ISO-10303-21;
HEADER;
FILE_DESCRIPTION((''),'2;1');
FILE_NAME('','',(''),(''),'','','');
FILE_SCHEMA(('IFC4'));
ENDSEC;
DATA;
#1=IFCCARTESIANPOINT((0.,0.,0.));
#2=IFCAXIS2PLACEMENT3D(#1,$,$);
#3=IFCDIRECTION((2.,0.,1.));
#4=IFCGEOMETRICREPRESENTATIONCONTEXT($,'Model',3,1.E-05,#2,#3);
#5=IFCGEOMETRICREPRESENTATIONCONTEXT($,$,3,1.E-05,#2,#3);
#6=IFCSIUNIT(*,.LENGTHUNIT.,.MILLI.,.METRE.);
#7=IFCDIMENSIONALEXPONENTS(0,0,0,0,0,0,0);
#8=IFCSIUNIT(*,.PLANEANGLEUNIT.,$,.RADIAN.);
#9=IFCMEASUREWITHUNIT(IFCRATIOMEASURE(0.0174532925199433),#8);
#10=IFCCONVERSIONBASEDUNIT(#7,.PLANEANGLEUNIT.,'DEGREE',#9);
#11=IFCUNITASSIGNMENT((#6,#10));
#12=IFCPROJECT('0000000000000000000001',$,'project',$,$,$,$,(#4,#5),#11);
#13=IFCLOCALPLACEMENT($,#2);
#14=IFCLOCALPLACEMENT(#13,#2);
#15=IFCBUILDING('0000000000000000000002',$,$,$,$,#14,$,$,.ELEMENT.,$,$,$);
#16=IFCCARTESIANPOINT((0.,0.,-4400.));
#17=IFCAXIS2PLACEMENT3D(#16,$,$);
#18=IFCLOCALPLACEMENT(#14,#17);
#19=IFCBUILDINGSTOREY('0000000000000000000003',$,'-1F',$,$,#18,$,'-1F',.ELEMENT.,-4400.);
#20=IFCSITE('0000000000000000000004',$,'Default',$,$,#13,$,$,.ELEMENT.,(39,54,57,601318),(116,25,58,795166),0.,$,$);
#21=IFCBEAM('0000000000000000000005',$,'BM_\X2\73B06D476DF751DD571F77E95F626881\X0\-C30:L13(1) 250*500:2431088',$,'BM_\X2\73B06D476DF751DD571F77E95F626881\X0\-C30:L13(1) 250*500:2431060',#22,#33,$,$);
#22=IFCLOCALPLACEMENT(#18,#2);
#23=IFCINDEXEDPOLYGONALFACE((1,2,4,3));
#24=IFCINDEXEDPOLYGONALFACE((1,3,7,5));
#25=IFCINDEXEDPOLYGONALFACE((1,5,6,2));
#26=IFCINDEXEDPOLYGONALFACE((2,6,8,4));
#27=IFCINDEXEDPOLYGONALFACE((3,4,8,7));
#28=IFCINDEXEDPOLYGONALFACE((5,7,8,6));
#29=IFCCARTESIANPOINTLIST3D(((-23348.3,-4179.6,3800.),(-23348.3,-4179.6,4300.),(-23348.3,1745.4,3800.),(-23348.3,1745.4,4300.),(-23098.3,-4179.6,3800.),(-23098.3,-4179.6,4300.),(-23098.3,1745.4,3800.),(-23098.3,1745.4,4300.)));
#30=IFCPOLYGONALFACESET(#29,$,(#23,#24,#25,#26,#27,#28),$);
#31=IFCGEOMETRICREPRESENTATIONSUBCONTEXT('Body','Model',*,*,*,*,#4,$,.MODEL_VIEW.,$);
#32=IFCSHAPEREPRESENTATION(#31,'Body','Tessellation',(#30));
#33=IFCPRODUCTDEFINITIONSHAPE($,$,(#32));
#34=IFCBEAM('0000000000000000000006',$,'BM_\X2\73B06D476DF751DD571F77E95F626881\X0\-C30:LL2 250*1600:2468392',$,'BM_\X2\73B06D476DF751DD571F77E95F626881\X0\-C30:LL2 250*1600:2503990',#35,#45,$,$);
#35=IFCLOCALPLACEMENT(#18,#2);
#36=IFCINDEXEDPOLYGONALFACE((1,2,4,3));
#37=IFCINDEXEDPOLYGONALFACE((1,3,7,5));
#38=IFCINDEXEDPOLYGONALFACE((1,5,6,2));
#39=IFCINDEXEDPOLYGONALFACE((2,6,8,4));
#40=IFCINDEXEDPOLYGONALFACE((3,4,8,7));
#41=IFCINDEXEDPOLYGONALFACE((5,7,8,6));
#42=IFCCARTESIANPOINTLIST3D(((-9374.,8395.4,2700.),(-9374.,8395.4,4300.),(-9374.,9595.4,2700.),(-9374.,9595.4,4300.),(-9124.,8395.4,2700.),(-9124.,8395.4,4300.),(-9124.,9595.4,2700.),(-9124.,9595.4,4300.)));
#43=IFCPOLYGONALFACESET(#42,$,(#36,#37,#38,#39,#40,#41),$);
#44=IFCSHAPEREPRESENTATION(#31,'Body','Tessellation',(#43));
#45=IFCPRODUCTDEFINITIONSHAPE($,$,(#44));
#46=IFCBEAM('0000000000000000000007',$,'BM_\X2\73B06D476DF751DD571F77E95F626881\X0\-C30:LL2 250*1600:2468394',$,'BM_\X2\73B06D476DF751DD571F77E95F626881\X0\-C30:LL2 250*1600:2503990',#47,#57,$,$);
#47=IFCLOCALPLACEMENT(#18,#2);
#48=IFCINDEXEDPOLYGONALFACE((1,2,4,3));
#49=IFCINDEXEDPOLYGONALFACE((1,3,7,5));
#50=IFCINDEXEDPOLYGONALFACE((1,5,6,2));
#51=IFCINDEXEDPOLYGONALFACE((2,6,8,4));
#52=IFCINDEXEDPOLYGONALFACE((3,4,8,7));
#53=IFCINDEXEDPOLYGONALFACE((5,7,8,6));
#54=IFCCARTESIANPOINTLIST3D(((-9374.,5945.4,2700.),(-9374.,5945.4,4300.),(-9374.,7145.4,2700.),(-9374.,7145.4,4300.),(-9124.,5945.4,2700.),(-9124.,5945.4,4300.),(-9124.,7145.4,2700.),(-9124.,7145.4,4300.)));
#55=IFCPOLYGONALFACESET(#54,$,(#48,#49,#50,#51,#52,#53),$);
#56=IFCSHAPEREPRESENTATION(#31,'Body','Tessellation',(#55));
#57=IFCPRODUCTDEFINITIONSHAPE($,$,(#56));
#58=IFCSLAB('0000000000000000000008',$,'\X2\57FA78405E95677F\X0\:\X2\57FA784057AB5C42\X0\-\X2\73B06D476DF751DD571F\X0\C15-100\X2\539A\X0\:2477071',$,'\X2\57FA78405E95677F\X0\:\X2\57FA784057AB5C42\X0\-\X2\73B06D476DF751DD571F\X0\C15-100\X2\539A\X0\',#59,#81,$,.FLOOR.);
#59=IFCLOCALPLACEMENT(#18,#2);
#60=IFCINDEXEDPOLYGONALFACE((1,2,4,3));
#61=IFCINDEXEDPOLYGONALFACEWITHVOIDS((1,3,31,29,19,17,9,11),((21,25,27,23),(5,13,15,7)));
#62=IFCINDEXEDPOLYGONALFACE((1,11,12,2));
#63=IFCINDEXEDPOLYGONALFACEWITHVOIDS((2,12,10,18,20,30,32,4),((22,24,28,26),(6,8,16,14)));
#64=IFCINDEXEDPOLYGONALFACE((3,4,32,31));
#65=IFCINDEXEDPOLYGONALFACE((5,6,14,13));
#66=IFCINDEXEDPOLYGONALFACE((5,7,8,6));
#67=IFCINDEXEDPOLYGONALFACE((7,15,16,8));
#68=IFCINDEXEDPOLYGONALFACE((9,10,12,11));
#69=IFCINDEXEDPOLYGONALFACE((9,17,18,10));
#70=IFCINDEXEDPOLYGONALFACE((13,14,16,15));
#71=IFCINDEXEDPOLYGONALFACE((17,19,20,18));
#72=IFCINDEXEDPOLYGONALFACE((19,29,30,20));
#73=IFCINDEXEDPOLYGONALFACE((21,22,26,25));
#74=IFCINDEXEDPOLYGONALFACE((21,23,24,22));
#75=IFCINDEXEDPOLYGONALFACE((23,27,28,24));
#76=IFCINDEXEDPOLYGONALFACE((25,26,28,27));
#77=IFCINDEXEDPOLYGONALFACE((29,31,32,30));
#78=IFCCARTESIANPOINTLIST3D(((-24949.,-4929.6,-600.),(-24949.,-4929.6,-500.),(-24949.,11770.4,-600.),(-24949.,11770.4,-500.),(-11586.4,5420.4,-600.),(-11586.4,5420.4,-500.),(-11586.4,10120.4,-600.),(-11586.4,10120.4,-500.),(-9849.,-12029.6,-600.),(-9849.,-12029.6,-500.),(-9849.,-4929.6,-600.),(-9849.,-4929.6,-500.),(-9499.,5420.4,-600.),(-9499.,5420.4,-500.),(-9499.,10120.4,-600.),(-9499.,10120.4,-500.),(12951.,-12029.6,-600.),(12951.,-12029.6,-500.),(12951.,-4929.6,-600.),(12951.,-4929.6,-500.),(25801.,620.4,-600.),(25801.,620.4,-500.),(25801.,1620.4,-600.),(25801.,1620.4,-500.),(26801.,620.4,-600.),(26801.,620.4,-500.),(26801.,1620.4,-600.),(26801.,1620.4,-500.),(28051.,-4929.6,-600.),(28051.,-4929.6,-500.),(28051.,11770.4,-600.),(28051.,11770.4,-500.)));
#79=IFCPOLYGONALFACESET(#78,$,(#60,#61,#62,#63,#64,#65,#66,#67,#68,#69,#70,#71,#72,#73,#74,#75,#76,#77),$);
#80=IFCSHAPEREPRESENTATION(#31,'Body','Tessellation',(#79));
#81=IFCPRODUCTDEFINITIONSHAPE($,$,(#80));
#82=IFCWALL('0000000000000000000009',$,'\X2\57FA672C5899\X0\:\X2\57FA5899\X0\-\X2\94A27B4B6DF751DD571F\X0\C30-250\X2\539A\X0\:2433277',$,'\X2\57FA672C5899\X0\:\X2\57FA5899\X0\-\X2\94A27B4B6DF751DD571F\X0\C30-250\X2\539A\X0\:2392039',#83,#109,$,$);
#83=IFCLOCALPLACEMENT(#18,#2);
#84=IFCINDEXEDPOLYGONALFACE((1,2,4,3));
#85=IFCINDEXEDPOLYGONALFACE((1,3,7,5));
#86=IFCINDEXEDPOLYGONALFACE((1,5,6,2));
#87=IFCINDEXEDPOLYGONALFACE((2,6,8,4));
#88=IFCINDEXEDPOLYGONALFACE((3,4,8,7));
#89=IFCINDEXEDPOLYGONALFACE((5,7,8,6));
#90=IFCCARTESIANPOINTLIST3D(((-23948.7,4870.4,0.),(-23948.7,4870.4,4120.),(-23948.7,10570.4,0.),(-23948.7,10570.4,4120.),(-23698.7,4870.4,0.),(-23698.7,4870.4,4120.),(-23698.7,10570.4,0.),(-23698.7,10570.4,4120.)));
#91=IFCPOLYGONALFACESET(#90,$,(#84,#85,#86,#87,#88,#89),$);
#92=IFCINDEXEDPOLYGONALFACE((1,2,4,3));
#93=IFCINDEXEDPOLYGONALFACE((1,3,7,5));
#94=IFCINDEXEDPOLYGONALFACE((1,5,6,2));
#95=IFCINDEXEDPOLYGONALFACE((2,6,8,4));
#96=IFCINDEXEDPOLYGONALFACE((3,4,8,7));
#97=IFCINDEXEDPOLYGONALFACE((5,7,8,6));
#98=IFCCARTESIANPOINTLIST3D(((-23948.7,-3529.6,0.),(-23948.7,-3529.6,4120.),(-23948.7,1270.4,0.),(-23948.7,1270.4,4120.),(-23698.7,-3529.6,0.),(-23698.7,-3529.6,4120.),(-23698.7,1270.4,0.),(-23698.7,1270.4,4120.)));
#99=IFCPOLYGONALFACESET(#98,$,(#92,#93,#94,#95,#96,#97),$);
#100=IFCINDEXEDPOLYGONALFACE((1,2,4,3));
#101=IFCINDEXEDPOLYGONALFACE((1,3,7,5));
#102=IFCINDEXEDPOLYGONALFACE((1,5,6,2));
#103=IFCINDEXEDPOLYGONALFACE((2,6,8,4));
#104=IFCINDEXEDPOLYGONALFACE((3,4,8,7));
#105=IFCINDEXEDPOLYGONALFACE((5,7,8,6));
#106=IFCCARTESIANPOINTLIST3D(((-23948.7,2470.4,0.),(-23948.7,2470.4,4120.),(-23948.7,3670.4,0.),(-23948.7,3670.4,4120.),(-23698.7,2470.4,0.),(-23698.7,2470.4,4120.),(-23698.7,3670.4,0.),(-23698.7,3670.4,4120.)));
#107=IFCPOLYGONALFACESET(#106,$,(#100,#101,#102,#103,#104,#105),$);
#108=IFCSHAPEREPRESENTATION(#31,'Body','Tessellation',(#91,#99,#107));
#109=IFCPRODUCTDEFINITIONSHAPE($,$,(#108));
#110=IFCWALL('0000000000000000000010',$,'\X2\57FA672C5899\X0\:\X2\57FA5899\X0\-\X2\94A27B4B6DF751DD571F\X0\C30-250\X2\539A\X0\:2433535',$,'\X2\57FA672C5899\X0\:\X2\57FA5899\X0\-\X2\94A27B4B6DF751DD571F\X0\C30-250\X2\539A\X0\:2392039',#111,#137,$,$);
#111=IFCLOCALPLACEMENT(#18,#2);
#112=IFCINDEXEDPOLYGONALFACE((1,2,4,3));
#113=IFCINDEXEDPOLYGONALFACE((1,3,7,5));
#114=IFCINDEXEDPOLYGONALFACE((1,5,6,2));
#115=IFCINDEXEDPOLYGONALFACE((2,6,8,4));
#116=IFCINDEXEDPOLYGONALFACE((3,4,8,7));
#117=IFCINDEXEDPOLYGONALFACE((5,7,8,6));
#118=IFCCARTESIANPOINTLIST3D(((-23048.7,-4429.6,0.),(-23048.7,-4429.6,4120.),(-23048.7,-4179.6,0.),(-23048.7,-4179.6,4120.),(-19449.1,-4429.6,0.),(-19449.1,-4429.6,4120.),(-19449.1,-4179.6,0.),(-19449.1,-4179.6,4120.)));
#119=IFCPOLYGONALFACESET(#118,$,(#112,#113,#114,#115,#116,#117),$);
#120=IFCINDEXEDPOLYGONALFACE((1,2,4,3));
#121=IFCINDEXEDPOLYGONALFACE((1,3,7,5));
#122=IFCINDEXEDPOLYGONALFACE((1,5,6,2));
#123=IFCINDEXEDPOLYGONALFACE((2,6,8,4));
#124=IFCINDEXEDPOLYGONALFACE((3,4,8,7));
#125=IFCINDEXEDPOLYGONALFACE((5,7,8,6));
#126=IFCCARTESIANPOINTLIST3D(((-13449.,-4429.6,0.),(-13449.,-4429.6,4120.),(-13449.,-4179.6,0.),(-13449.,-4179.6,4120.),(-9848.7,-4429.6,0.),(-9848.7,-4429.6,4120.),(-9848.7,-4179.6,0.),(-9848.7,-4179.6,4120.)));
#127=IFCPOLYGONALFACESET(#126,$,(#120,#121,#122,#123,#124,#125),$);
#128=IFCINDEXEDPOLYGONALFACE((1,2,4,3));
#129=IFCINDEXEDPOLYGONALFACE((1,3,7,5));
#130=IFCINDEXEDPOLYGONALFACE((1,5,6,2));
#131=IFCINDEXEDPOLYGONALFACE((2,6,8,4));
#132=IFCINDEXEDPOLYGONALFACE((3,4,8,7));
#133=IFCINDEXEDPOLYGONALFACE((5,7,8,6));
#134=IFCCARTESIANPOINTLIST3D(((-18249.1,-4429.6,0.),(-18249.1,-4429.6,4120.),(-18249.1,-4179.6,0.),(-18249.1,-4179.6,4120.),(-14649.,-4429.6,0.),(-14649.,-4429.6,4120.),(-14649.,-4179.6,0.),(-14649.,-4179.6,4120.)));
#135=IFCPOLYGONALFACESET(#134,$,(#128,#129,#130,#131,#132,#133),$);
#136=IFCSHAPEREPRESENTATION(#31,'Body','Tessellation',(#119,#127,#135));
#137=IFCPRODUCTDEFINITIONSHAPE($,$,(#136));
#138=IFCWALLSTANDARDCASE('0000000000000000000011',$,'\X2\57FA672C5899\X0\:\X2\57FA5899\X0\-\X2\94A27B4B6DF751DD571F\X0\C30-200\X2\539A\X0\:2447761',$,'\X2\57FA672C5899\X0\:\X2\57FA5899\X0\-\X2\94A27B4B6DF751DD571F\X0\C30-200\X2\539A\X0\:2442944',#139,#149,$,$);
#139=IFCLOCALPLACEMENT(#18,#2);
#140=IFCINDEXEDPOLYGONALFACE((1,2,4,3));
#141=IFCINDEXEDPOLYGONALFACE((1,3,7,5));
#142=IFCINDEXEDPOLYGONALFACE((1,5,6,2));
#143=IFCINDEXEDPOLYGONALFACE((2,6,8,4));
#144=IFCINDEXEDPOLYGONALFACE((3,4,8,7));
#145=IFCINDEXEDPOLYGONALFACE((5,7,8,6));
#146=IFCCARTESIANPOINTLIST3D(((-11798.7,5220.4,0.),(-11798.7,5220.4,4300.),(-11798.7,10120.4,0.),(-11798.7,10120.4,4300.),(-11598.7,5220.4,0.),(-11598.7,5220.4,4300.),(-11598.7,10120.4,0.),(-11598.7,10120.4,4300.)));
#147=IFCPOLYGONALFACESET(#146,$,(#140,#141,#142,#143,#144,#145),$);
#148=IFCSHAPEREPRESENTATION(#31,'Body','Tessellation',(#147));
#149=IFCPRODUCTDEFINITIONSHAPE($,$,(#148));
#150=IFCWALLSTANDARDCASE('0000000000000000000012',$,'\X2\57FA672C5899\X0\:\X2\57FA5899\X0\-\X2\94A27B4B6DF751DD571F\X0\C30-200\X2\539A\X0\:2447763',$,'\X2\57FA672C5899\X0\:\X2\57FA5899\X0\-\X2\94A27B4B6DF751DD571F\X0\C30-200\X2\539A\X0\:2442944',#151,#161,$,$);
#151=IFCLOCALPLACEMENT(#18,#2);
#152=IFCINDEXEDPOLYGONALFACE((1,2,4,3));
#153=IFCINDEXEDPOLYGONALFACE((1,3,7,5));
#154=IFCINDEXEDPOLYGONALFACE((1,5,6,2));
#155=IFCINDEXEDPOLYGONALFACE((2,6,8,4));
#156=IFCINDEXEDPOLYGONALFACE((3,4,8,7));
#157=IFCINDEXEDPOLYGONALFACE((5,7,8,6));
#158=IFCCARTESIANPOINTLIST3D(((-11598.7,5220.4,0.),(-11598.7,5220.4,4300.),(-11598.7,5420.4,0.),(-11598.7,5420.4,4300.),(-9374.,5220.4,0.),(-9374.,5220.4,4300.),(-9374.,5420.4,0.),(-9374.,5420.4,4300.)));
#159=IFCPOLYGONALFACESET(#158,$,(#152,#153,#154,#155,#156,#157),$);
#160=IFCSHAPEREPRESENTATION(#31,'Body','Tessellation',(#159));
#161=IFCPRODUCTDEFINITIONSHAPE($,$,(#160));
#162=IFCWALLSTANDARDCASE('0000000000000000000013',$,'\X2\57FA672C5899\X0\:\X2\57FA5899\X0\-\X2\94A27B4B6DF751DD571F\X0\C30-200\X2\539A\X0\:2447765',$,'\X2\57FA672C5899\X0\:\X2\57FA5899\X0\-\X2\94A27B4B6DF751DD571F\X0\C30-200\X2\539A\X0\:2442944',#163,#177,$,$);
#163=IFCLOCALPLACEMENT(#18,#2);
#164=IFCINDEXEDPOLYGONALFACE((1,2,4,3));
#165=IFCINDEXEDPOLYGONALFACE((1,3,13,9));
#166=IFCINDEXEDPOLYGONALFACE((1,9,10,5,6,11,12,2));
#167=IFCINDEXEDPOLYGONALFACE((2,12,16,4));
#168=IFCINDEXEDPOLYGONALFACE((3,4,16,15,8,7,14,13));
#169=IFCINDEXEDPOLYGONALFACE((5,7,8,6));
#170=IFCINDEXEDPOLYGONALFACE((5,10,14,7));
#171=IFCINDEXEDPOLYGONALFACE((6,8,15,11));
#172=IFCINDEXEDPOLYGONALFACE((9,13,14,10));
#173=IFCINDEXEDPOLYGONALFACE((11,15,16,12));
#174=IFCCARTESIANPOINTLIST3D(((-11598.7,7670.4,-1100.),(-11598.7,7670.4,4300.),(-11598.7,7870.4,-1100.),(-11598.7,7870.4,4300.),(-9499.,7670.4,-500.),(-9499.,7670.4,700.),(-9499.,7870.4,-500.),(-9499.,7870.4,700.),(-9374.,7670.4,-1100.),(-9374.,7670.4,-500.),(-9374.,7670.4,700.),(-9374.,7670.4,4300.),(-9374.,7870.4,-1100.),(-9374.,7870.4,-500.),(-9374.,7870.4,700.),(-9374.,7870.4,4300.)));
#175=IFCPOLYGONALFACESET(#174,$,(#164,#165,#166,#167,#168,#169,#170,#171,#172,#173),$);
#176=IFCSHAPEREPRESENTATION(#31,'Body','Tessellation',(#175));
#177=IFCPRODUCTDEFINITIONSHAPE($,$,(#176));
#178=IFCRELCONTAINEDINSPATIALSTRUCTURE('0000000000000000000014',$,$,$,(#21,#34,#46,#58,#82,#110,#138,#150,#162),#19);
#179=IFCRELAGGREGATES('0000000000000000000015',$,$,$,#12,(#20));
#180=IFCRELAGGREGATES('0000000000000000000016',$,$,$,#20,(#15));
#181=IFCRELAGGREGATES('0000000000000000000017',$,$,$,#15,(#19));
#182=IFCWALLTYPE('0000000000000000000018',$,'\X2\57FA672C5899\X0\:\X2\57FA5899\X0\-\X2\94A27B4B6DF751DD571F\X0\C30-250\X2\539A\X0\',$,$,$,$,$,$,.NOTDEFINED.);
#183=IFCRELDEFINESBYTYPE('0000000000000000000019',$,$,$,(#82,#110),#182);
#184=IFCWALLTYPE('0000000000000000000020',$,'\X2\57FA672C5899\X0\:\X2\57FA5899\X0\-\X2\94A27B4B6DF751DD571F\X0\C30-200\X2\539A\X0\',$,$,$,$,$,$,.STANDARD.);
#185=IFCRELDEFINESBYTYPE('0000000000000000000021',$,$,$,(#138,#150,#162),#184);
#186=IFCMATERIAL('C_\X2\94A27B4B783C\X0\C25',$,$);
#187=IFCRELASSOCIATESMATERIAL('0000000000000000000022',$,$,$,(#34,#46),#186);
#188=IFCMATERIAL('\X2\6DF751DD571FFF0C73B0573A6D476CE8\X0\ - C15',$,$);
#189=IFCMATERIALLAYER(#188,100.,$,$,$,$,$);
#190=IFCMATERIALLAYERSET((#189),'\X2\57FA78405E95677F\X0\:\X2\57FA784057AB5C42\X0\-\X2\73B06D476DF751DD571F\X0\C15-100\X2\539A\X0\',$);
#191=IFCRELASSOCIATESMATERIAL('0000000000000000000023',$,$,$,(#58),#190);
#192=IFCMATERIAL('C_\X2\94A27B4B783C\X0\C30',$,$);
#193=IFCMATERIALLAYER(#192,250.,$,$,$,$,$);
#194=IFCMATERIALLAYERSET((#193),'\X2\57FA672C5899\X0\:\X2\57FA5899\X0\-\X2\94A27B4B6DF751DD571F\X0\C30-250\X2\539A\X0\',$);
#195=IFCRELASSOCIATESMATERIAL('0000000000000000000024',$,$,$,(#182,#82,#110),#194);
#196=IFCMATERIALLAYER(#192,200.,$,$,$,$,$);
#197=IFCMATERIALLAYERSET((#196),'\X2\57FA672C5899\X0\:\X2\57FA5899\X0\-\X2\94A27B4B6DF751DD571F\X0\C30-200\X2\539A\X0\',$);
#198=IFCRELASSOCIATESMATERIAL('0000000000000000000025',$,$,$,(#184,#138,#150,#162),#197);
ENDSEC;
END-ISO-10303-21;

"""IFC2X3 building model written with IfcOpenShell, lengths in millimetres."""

from ifc_helpers import new_model, entity, si_unit, converted_unit, direction, frame, frame_2d, origin, origin_2d_with_axis, place, context, subcontext, project, spatial, polyline, rectangle, outline, extrude, clip, bounded_halfspace, material, layer, layer_set, layer_usage, type_object, element, save


model = new_model("IFC2X3")

# Units and contexts
model_context = context("Model", 3, precision=1e-05, world=origin(), true_north=direction((2.0, 0.0, 1.0)))
context_of_model = context(None, 3, precision=1e-05, world=origin(), true_north=direction((2.0, 0.0, 1.0)))
body_context = subcontext(model_context, "Body", "Model", "MODEL_VIEW")
ifc_project = project(units=[si_unit("LENGTHUNIT", "METRE", prefix="MILLI"), converted_unit("PLANEANGLEUNIT", "DEGREE", entity("IfcRatioMeasure", 0.0174532925199433), si_unit("PLANEANGLEUNIT", "RADIAN"), dimensions=[0, 0, 0, 0, 0, 0, 0])], contexts=[model_context, context_of_model])

# Site, building, storey
site_placement = place(None, origin())
site = spatial("IfcSite", under=ifc_project, at=site_placement, Name="Default", CompositionType="ELEMENT", RefLatitude=(39, 54, 57, 601318), RefLongitude=(116, 25, 58, 795166), RefElevation=0.0)
building_placement = place(site_placement, origin())
building = spatial("IfcBuilding", under=site, at=building_placement, CompositionType="ELEMENT")
storey_placement = place(building_placement, frame((0.0, 0.0, -4400.0)))
storey = spatial("IfcBuildingStorey", under=building, at=storey_placement, Name="-1F", LongName="-1F", CompositionType="ELEMENT", Elevation=-4400.0)

# Beams
ifc_material_1 = material(Name="C_钢筋砼C30")
beam_1_placement = place(storey_placement, frame((-23223.3, -4179.6, 4300.0), z_axis=(0.0, 0.0, 1.0), x_axis=(0.0, 1.0, 0.0)))
element("IfcBeam", 1, at=beam_1_placement, inside=storey, Name="BM_现浇混凝土矩形梁-C30:L13(1) 250*500:2431088", ObjectType="BM_现浇混凝土矩形梁-C30:L13(1) 250*500:2431060", context=body_context, shape_type="SweptSolid", body=[
    extrude(rectangle(XDim=500.0, YDim=250.0, at=origin_2d_with_axis()), frame((0.0, 0.0, -250.0), z_axis=(1.0, 0.0, 0.0), x_axis=(0.0, 0.0, -1.0)), (0.0, 0.0, 1.0), 5925.0),
])
ifc_material_2 = material(Name="C_钢筋砼C25")
for number, where, z_axis, x_axis, name in (
    (2, (-9249.0, 9795.4, 4300.0), (0.0, 0.0, 1.0), (0.0, -1.0, 0.0), "BM_现浇混凝土矩形梁-C30:LL2 250*1600:2468392"),
    (3, (-9249.0, 7345.4, 4300.0), (0.0, 0.0, 1.0), (0.0, -1.0, 0.0), "BM_现浇混凝土矩形梁-C30:LL2 250*1600:2468394"),
):
    element("IfcBeam", number, at=place(storey_placement, frame(where, z_axis=z_axis, x_axis=x_axis)), inside=storey, material=ifc_material_2, Name=name, ObjectType="BM_现浇混凝土矩形梁-C30:LL2 250*1600:2503990", context=body_context, shape_type="SweptSolid", body=[
        extrude(rectangle(XDim=1600.0, YDim=250.0, at=frame_2d((0.0, 0.0), x_axis=(1.0, 0.0))), frame((200.0, 0.0, -800.0), z_axis=(1.0, 0.0, 0.0), x_axis=(0.0, 0.0, -1.0)), (0.0, 0.0, 1.0), 1200.0),
    ])

# Slab, openings
ifc_material_3 = material(Name="混凝土，现场浇注 - C15")
ifc_layer_1 = layer(ifc_material_3, 100.0)
ifc_layer_set_1 = layer_set([ifc_layer_1], Name="基础底板:基础垫层-现浇混凝土C15-100厚")
ifc_layer_usage_1 = layer_usage(ifc_layer_set_1, "AXIS3", "POSITIVE", 0.0)
slab_placement = place(storey_placement, frame((-24949.0, -12029.6, -600.0)))
slab = element("IfcSlab", 4, at=slab_placement, inside=storey, material=ifc_layer_usage_1, Name="基础底板:基础垫层-现浇混凝土C15-100厚:2477071", ObjectType="基础底板:基础垫层-现浇混凝土C15-100厚", PredefinedType="FLOOR", context=body_context, shape_type="SweptSolid", body=[
    extrude(outline(polyline([(26500.0, 11900.0), (-26500.0, 11900.0), (-26500.0, -4800.0), (-11400.0, -4800.0), (-11400.0, -11900.0), (11400.0, -11900.0), (11400.0, -4800.0), (26500.0, -4800.0), (26500.0, 11900.0)])), frame((26500.0, 11900.0, 100.0), z_axis=(0.0, 0.0, -1.0), x_axis=(-1.0, 0.0, 0.0)), (0.0, 0.0, 1.0), 100.0),
])
opening_1_placement = place(slab_placement, frame((14406.3, 19800.0, 100.0)))
element("IfcOpeningElement", 5, at=opening_1_placement, cuts=slab, ObjectType="Opening", context=body_context, shape_type="SweptSolid", body=[
    extrude(rectangle(XDim=2087.3, YDim=4700.0, at=origin_2d_with_axis()), frame((0.0, 0.0, 0.0), z_axis=(0.0, 0.0, -1.0), x_axis=(-1.0, 0.0, 0.0)), (0.0, 0.0, 1.0), 100.0),
])
opening_2_placement = place(slab_placement, frame((51250.0, 13150.0, 100.0)))
element("IfcOpeningElement", 6, at=opening_2_placement, cuts=slab, ObjectType="Opening", context=body_context, shape_type="SweptSolid", body=[
    extrude(rectangle(XDim=1000.0, YDim=1000.0, at=origin_2d_with_axis()), frame((0.0, 0.0, 0.0), z_axis=(0.0, 0.0, -1.0), x_axis=(1.0, 0.0, 0.0)), (0.0, 0.0, 1.0), 100.0),
])

# Walls
ifc_layer_2 = layer(ifc_material_1, 250.0)
ifc_layer_set_2 = layer_set([ifc_layer_2], Name="基本墙:基墙-钢筋混凝土C30-250厚")
wall_type_1 = type_object("IfcWallType", Name="基本墙:基墙-钢筋混凝土C30-250厚", PredefinedType="NOTDEFINED", material=ifc_layer_set_2)
wall_1_placement = place(storey_placement, frame((-23823.7, 10570.4, 0.0), z_axis=(0.0, 0.0, 1.0), x_axis=(0.0, -1.0, 0.0)))
element("IfcWall", 7, at=wall_1_placement, inside=storey, type_object=wall_type_1, material=ifc_layer_set_2, Name="基本墙:基墙-钢筋混凝土C30-250厚:2433277", ObjectType="基本墙:基墙-钢筋混凝土C30-250厚:2392039", context=body_context, shape_type="SweptSolid", body=[
    extrude(rectangle(XDim=5700.0, YDim=250.0, at=frame_2d((0.0, 0.0), x_axis=(1.0, 0.0))), frame((2850.0, 0.0, 0.0)), (0.0, 0.0, 1.0), 4120.0),
    extrude(rectangle(XDim=4800.0, YDim=250.0, at=frame_2d((0.0, 0.0), x_axis=(1.0, 0.0))), frame((11700.0, 0.0, 0.0), z_axis=(0.0, 0.0, 1.0), x_axis=(-1.0, 0.0, 0.0)), (0.0, 0.0, 1.0), 4120.0),
    extrude(rectangle(XDim=250.0, YDim=1200.0, at=frame_2d((0.0, 0.0), x_axis=(1.0, 0.0))), frame((7500.0, 0.0, 0.0), z_axis=(0.0, 0.0, 1.0), x_axis=(0.0, 1.0, 0.0)), (0.0, 0.0, 1.0), 4120.0),
])
wall_2_placement = place(storey_placement, frame((-23048.7, -4304.6, 0.0)))
element("IfcWall", 8, at=wall_2_placement, inside=storey, type_object=wall_type_1, material=ifc_layer_set_2, Name="基本墙:基墙-钢筋混凝土C30-250厚:2433535", ObjectType="基本墙:基墙-钢筋混凝土C30-250厚:2392039", context=body_context, shape_type="SweptSolid", body=[
    extrude(rectangle(XDim=3599.6, YDim=250.0, at=frame_2d((0.0, 0.0), x_axis=(1.0, 0.0))), frame((1799.8, 0.0, 0.0)), (0.0, 0.0, 1.0), 4120.0),
    extrude(rectangle(XDim=250.0, YDim=3600.4, at=origin_2d_with_axis()), frame((11399.8, 0.0, 0.0), z_axis=(0.0, 0.0, 1.0), x_axis=(0.0, 1.0, 0.0)), (0.0, 0.0, 1.0), 4120.0),
    extrude(rectangle(XDim=250.0, YDim=3600.0, at=frame_2d((0.0, 0.0), x_axis=(1.0, 0.0))), frame((6599.6, 0.0, 0.0), z_axis=(0.0, 0.0, 1.0), x_axis=(0.0, 1.0, 0.0)), (0.0, 0.0, 1.0), 4120.0),
])
ifc_layer_3 = layer(ifc_material_1, 200.0)
ifc_layer_set_3 = layer_set([ifc_layer_3], Name="基本墙:基墙-钢筋混凝土C30-200厚")
ifc_layer_usage_2 = layer_usage(ifc_layer_set_3, "AXIS2", "POSITIVE", -100.0)
wall_type_2 = type_object("IfcWallType", Name="基本墙:基墙-钢筋混凝土C30-200厚", PredefinedType="STANDARD", material=ifc_layer_set_3)
wall_3_placement = place(storey_placement, frame((-11698.7, 10120.4, 0.0), z_axis=(0.0, 0.0, 1.0), x_axis=(0.0, -1.0, 0.0)))
element("IfcWallStandardCase", 9, at=wall_3_placement, inside=storey, type_object=wall_type_2, material=ifc_layer_usage_2, Name="基本墙:基墙-钢筋混凝土C30-200厚:2447761", ObjectType="基本墙:基墙-钢筋混凝土C30-200厚:2442944", context=body_context, shape_type="SweptSolid", body=[
    extrude(rectangle(XDim=4900.0, YDim=200.0, at=frame_2d((2450.0, 0.0), x_axis=(-1.0, 0.0))), origin(), (0.0, 0.0, 1.0), 4300.0),
])
ifc_layer_usage_3 = layer_usage(ifc_layer_set_3, "AXIS2", "POSITIVE", -100.0)
wall_4_placement = place(storey_placement, frame((-11598.7, 5320.4, 0.0)))
element("IfcWallStandardCase", 10, at=wall_4_placement, inside=storey, type_object=wall_type_2, material=ifc_layer_usage_3, Name="基本墙:基墙-钢筋混凝土C30-200厚:2447763", ObjectType="基本墙:基墙-钢筋混凝土C30-200厚:2442944", context=body_context, shape_type="SweptSolid", body=[
    extrude(rectangle(XDim=2224.6, YDim=200.0, at=frame_2d((1112.3, 0.0), x_axis=(-1.0, 0.0))), origin(), (0.0, 0.0, 1.0), 4300.0),
])
ifc_layer_usage_4 = layer_usage(ifc_layer_set_3, "AXIS2", "POSITIVE", -100.0)
wall_5_placement = place(storey_placement, frame((-11598.7, 7770.4, -1100.0)))
element("IfcWallStandardCase", 11, at=wall_5_placement, inside=storey, type_object=wall_type_2, material=ifc_layer_usage_4, Name="基本墙:基墙-钢筋混凝土C30-200厚:2447765", ObjectType="基本墙:基墙-钢筋混凝土C30-200厚:2442944", context=body_context, shape_type="Clipping", body=[
    clip(extrude(rectangle(XDim=2224.6, YDim=200.0, at=frame_2d((1112.3, 0.0), x_axis=(-1.0, 0.0))), origin(), (0.0, 0.0, 1.0), 5400.0), bounded_halfspace(frame((2099.6, 100.0, 1800.0), z_axis=(-1.0, 0.0, 0.0), x_axis=(0.0, 1.0, 0.0)), True, frame((2099.6, 100.0, 1800.0), z_axis=(-1.0, 0.0, 0.0), x_axis=(0.0, 1.0, 0.0)), polyline([(0.0, 0.0), (0.0, 1200.0), (-200.0, 1200.0), (-200.0, 0.0), (0.0, 0.0)]))),
])

save(model, "model.ifc")
